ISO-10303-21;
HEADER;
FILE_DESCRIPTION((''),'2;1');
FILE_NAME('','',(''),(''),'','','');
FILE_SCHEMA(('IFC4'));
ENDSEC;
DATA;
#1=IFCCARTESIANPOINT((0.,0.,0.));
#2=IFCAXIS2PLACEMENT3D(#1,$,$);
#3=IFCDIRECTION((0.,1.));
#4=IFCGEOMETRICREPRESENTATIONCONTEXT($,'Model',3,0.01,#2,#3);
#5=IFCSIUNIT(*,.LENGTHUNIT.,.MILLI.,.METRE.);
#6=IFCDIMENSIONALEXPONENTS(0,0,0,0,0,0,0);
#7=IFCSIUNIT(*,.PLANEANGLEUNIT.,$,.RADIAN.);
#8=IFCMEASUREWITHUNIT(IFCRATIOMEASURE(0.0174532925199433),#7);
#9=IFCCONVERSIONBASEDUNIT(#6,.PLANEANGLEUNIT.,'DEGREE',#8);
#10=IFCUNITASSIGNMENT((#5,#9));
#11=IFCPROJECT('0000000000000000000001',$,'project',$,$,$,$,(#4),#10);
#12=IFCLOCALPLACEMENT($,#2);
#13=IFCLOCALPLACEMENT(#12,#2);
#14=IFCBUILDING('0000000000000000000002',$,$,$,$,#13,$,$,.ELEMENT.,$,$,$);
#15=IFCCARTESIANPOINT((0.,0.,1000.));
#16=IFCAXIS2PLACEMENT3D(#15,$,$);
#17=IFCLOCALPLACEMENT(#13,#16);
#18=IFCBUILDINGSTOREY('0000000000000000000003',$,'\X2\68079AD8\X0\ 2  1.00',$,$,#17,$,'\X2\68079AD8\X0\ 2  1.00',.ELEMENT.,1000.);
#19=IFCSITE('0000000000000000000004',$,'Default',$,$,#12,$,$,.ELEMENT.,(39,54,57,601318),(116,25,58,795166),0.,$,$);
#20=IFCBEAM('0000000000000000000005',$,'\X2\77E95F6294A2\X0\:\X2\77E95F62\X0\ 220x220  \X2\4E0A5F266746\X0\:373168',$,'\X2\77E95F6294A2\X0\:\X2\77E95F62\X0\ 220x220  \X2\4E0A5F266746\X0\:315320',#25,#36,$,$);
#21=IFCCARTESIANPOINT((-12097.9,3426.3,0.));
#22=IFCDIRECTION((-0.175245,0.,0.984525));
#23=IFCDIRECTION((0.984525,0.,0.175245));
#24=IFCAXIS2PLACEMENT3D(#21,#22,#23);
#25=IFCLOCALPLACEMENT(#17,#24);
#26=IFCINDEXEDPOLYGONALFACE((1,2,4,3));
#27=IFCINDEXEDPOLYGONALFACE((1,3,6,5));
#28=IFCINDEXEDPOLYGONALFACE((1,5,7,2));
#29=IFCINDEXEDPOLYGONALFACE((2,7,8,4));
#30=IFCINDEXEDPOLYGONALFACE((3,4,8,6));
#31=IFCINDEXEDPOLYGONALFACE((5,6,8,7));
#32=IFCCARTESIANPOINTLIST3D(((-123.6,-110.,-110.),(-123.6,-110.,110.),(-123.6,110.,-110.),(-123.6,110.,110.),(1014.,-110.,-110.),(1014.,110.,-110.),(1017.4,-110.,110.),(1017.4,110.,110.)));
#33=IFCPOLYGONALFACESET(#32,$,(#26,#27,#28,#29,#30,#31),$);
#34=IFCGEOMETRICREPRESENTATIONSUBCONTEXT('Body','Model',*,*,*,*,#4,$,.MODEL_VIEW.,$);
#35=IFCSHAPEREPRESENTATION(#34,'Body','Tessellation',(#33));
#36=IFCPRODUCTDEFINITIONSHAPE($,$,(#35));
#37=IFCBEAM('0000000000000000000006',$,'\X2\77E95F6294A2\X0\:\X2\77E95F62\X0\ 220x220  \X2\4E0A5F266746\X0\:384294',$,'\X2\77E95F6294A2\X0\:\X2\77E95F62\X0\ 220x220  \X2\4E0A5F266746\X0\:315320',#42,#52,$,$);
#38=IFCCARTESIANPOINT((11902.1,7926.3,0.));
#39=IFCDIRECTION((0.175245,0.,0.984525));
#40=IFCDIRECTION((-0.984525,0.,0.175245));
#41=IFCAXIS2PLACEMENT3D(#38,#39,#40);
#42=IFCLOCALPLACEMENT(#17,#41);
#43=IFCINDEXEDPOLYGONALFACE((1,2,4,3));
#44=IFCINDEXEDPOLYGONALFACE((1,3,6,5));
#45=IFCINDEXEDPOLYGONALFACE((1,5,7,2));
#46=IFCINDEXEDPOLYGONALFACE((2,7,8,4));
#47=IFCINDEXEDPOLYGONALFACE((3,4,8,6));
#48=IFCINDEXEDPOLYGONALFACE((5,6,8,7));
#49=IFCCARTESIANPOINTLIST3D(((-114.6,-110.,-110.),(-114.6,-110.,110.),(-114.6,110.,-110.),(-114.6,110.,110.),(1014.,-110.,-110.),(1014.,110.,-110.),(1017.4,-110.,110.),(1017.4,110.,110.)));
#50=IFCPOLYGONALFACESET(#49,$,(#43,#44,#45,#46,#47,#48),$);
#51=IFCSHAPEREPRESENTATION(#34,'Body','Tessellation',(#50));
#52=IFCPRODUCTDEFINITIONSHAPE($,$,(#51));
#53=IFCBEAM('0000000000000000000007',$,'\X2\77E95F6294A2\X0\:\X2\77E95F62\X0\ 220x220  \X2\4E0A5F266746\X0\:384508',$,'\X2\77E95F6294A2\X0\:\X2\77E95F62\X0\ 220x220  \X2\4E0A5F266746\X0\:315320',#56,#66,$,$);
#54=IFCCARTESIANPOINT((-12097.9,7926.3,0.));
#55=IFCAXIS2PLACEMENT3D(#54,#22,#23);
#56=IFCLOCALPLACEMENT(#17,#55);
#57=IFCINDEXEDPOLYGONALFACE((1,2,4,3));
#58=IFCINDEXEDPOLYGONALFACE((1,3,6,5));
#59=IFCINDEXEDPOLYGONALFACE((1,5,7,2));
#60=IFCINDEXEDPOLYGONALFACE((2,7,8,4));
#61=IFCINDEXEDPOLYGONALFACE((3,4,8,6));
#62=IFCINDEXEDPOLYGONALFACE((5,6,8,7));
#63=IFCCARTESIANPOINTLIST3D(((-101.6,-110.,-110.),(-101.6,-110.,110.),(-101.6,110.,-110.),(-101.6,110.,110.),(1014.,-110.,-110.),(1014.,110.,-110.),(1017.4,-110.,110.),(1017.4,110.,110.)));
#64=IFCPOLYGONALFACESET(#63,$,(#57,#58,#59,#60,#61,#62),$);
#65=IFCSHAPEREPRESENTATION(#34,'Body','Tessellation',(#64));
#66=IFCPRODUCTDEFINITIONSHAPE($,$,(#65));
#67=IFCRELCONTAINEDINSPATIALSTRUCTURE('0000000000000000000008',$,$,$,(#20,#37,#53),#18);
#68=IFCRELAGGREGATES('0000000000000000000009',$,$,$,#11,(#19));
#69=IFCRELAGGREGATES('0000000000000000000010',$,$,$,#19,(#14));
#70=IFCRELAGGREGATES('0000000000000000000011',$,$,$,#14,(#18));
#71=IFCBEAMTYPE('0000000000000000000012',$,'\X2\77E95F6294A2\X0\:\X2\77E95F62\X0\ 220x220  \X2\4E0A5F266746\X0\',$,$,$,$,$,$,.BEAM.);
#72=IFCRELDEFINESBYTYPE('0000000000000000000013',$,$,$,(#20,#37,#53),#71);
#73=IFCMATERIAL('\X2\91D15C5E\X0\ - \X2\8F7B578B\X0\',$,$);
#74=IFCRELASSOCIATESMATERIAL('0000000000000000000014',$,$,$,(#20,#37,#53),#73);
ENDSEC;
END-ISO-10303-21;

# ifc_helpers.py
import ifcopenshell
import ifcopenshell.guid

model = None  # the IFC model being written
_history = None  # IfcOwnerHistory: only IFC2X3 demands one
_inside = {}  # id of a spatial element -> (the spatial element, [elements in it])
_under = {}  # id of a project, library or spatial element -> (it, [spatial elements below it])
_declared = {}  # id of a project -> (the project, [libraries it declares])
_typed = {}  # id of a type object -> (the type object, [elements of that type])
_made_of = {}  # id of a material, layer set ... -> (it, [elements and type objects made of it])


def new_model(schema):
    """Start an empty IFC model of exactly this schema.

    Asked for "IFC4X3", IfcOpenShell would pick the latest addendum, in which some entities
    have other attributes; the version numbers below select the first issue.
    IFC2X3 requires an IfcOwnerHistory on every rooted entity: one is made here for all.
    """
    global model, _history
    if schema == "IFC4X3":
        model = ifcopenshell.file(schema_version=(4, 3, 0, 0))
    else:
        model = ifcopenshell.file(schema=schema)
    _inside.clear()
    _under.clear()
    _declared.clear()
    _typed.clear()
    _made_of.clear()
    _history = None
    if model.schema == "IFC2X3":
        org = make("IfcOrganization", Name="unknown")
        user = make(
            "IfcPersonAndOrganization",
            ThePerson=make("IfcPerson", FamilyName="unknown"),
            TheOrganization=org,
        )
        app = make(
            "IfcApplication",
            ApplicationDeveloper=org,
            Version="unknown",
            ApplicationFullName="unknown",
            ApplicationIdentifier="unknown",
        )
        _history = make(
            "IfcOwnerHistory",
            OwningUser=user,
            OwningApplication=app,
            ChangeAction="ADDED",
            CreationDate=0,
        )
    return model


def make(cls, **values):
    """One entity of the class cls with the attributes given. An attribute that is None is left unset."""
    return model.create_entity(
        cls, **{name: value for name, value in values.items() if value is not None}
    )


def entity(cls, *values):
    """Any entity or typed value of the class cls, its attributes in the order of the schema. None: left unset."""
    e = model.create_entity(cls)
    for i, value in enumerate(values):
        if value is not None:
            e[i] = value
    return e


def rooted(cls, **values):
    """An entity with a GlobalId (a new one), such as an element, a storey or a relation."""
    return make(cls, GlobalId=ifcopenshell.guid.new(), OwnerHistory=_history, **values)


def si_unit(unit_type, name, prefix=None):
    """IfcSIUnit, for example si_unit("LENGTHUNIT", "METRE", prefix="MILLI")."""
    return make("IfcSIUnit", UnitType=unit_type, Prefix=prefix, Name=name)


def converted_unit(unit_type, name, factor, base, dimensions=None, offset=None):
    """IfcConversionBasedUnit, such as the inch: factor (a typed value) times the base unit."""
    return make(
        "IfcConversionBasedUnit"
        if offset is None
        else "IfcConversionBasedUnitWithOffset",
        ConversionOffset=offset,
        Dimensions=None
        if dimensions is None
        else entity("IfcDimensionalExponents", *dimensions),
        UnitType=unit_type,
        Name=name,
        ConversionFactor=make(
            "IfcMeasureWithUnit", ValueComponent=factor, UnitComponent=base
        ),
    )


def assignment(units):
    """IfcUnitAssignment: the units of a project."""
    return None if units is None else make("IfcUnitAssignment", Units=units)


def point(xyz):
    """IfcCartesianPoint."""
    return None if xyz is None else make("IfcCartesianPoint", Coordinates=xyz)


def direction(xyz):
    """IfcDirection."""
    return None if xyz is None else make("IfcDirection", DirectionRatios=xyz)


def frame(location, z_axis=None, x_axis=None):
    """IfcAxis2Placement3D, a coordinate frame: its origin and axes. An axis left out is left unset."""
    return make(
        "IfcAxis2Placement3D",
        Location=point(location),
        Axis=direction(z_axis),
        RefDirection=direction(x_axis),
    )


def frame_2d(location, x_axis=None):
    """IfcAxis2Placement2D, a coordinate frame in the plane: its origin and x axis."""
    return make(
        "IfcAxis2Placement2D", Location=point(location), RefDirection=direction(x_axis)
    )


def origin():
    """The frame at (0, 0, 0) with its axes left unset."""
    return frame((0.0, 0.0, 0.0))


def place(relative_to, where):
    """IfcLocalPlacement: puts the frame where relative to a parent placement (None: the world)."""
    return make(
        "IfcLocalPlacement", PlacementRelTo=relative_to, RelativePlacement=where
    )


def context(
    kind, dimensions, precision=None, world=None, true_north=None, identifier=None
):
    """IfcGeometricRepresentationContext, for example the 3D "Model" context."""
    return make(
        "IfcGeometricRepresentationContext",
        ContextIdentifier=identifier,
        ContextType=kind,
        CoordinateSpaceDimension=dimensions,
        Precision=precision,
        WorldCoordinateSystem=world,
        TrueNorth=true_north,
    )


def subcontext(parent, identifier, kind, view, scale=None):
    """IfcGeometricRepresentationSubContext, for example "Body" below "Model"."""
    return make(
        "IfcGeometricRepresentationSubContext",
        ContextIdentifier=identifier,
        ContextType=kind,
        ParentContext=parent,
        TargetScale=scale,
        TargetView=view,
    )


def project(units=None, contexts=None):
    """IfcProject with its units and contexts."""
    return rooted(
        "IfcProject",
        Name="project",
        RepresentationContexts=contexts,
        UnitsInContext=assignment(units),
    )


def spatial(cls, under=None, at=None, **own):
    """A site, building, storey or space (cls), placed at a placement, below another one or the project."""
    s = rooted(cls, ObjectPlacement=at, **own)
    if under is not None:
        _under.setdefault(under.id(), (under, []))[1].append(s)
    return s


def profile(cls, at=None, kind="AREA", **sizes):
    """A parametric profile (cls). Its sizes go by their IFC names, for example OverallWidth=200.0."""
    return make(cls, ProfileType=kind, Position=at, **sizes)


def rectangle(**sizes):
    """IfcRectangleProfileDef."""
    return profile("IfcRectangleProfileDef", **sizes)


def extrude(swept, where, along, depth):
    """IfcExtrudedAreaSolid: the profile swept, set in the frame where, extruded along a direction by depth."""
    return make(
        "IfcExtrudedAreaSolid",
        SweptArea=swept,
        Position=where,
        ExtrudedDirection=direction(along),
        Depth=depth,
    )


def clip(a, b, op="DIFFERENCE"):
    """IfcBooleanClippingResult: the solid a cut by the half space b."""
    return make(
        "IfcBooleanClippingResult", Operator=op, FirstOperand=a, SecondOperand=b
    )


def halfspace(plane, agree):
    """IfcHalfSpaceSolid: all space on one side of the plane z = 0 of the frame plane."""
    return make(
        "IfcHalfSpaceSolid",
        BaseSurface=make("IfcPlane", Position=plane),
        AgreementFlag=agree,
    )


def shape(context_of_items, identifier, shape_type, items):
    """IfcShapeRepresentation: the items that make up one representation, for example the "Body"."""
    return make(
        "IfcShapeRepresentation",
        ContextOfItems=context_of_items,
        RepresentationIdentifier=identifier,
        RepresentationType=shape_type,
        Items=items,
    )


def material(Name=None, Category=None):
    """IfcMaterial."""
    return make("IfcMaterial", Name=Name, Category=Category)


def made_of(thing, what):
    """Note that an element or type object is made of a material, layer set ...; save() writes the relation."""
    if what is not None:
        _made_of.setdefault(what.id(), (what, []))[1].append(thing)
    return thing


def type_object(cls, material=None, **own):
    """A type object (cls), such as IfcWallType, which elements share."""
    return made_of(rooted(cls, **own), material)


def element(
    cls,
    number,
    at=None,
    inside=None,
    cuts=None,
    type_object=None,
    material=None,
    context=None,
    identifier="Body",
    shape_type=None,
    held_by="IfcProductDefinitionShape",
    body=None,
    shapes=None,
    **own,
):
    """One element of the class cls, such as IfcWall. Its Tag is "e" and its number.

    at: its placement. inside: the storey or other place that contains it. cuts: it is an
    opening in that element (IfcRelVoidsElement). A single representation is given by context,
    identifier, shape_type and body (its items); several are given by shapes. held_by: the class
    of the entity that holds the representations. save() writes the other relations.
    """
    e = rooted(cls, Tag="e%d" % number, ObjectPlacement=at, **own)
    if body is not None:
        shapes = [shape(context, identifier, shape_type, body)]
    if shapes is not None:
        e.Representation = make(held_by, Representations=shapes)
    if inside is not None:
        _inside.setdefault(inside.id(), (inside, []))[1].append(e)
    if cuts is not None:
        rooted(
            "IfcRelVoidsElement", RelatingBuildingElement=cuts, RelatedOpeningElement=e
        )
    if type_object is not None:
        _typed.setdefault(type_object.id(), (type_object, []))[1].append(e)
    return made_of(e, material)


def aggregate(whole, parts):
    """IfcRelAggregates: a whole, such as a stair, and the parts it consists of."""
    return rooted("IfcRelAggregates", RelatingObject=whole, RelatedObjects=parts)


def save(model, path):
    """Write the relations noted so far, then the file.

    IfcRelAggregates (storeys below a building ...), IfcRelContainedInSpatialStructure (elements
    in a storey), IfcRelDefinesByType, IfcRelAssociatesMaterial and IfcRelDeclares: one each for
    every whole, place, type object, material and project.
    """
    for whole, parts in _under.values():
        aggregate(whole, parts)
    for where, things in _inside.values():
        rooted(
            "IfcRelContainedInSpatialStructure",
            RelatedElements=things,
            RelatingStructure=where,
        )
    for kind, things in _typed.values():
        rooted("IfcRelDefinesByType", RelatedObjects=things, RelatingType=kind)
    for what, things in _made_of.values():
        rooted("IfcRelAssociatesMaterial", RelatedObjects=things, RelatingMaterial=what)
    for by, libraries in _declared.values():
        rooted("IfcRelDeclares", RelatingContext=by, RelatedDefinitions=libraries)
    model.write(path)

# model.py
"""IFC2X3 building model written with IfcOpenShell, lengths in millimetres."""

from ifc_helpers import new_model, entity, si_unit, converted_unit, direction, frame, frame_2d, origin, place, context, subcontext, project, spatial, rectangle, extrude, clip, halfspace, material, type_object, element, save


model = new_model("IFC2X3")

# Units and contexts
model_context = context("Model", 3, precision=0.01, world=origin(), true_north=direction((0.0, 1.0)))
body_context = subcontext(model_context, "Body", "Model", "MODEL_VIEW")
ifc_project = project(units=[si_unit("LENGTHUNIT", "METRE", prefix="MILLI"), converted_unit("PLANEANGLEUNIT", "DEGREE", entity("IfcRatioMeasure", 0.0174532925199433), si_unit("PLANEANGLEUNIT", "RADIAN"), dimensions=[0, 0, 0, 0, 0, 0, 0])], contexts=[model_context])

# Site, building, storey
site_placement = place(None, origin())
site = spatial("IfcSite", under=ifc_project, at=site_placement, Name="Default", CompositionType="ELEMENT", RefLatitude=(39, 54, 57, 601318), RefLongitude=(116, 25, 58, 795166), RefElevation=0.0)
building_placement = place(site_placement, origin())
building = spatial("IfcBuilding", under=site, at=building_placement, CompositionType="ELEMENT")
storey_placement = place(building_placement, frame((0.0, 0.0, 1000.0)))
storey = spatial("IfcBuildingStorey", under=building, at=storey_placement, Name="标高 2  1.00", LongName="标高 2  1.00", CompositionType="ELEMENT", Elevation=1000.0)

# Beams
ifc_material = material(Name="金属 - 轻型")
beam_type = type_object("IfcBeamType", Name="矩形钢:矩形 220x220  上弦杆", PredefinedType="BEAM")
beam_1_placement = place(storey_placement, frame((-12097.9, 3426.3, 0.0), z_axis=(-0.175245, 0.0, 0.984525), x_axis=(0.984525, 0.0, 0.175245)))
element("IfcBeam", 1, at=beam_1_placement, inside=storey, type_object=beam_type, material=ifc_material, Name="矩形钢:矩形 220x220  上弦杆:373168", ObjectType="矩形钢:矩形 220x220  上弦杆:315320", context=body_context, shape_type="Clipping", body=[
    clip(extrude(rectangle(XDim=220.0, YDim=220.0, at=frame_2d((0.0, 0.0), x_axis=(1.0, 0.0))), frame((-123.6, 0.0, 0.0), z_axis=(1.0, 0.0, 0.0), x_axis=(0.0, 0.0, -1.0)), (0.0, 0.0, 1.0), 1141.0), halfspace(frame((1017.4, 0.0, 110.0), z_axis=(0.999882, 0.0, -0.015344), x_axis=(-0.015344, 0.0, -0.999882)), False)),
])
beam_2_placement = place(storey_placement, frame((11902.1, 7926.3, 0.0), z_axis=(0.175245, 0.0, 0.984525), x_axis=(-0.984525, 0.0, 0.175245)))
element("IfcBeam", 2, at=beam_2_placement, inside=storey, type_object=beam_type, material=ifc_material, Name="矩形钢:矩形 220x220  上弦杆:384294", ObjectType="矩形钢:矩形 220x220  上弦杆:315320", context=body_context, shape_type="Clipping", body=[
    clip(extrude(rectangle(XDim=220.0, YDim=220.0, at=frame_2d((0.0, 0.0), x_axis=(1.0, 0.0))), frame((-114.6, 0.0, 0.0), z_axis=(1.0, 0.0, 0.0), x_axis=(0.0, 0.0, -1.0)), (0.0, 0.0, 1.0), 1132.0), halfspace(frame((1017.4, 0.0, 110.0), z_axis=(0.999882, 0.0, -0.015344), x_axis=(0.015344, 0.0, 0.999882)), False)),
])
beam_3_placement = place(storey_placement, frame((-12097.9, 7926.3, 0.0), z_axis=(-0.175245, 0.0, 0.984525), x_axis=(0.984525, 0.0, 0.175245)))
element("IfcBeam", 3, at=beam_3_placement, inside=storey, type_object=beam_type, material=ifc_material, Name="矩形钢:矩形 220x220  上弦杆:384508", ObjectType="矩形钢:矩形 220x220  上弦杆:315320", context=body_context, shape_type="Clipping", body=[
    clip(extrude(rectangle(XDim=220.0, YDim=220.0, at=frame_2d((0.0, 0.0), x_axis=(1.0, 0.0))), frame((-101.6, 0.0, 0.0), z_axis=(1.0, 0.0, 0.0), x_axis=(0.0, 0.0, -1.0)), (0.0, 0.0, 1.0), 1119.0), halfspace(frame((1017.4, 0.0, 110.0), z_axis=(0.999882, 0.0, -0.015344), x_axis=(-0.015344, 0.0, -0.999882)), False)),
])

save(model, "model.ifc")
